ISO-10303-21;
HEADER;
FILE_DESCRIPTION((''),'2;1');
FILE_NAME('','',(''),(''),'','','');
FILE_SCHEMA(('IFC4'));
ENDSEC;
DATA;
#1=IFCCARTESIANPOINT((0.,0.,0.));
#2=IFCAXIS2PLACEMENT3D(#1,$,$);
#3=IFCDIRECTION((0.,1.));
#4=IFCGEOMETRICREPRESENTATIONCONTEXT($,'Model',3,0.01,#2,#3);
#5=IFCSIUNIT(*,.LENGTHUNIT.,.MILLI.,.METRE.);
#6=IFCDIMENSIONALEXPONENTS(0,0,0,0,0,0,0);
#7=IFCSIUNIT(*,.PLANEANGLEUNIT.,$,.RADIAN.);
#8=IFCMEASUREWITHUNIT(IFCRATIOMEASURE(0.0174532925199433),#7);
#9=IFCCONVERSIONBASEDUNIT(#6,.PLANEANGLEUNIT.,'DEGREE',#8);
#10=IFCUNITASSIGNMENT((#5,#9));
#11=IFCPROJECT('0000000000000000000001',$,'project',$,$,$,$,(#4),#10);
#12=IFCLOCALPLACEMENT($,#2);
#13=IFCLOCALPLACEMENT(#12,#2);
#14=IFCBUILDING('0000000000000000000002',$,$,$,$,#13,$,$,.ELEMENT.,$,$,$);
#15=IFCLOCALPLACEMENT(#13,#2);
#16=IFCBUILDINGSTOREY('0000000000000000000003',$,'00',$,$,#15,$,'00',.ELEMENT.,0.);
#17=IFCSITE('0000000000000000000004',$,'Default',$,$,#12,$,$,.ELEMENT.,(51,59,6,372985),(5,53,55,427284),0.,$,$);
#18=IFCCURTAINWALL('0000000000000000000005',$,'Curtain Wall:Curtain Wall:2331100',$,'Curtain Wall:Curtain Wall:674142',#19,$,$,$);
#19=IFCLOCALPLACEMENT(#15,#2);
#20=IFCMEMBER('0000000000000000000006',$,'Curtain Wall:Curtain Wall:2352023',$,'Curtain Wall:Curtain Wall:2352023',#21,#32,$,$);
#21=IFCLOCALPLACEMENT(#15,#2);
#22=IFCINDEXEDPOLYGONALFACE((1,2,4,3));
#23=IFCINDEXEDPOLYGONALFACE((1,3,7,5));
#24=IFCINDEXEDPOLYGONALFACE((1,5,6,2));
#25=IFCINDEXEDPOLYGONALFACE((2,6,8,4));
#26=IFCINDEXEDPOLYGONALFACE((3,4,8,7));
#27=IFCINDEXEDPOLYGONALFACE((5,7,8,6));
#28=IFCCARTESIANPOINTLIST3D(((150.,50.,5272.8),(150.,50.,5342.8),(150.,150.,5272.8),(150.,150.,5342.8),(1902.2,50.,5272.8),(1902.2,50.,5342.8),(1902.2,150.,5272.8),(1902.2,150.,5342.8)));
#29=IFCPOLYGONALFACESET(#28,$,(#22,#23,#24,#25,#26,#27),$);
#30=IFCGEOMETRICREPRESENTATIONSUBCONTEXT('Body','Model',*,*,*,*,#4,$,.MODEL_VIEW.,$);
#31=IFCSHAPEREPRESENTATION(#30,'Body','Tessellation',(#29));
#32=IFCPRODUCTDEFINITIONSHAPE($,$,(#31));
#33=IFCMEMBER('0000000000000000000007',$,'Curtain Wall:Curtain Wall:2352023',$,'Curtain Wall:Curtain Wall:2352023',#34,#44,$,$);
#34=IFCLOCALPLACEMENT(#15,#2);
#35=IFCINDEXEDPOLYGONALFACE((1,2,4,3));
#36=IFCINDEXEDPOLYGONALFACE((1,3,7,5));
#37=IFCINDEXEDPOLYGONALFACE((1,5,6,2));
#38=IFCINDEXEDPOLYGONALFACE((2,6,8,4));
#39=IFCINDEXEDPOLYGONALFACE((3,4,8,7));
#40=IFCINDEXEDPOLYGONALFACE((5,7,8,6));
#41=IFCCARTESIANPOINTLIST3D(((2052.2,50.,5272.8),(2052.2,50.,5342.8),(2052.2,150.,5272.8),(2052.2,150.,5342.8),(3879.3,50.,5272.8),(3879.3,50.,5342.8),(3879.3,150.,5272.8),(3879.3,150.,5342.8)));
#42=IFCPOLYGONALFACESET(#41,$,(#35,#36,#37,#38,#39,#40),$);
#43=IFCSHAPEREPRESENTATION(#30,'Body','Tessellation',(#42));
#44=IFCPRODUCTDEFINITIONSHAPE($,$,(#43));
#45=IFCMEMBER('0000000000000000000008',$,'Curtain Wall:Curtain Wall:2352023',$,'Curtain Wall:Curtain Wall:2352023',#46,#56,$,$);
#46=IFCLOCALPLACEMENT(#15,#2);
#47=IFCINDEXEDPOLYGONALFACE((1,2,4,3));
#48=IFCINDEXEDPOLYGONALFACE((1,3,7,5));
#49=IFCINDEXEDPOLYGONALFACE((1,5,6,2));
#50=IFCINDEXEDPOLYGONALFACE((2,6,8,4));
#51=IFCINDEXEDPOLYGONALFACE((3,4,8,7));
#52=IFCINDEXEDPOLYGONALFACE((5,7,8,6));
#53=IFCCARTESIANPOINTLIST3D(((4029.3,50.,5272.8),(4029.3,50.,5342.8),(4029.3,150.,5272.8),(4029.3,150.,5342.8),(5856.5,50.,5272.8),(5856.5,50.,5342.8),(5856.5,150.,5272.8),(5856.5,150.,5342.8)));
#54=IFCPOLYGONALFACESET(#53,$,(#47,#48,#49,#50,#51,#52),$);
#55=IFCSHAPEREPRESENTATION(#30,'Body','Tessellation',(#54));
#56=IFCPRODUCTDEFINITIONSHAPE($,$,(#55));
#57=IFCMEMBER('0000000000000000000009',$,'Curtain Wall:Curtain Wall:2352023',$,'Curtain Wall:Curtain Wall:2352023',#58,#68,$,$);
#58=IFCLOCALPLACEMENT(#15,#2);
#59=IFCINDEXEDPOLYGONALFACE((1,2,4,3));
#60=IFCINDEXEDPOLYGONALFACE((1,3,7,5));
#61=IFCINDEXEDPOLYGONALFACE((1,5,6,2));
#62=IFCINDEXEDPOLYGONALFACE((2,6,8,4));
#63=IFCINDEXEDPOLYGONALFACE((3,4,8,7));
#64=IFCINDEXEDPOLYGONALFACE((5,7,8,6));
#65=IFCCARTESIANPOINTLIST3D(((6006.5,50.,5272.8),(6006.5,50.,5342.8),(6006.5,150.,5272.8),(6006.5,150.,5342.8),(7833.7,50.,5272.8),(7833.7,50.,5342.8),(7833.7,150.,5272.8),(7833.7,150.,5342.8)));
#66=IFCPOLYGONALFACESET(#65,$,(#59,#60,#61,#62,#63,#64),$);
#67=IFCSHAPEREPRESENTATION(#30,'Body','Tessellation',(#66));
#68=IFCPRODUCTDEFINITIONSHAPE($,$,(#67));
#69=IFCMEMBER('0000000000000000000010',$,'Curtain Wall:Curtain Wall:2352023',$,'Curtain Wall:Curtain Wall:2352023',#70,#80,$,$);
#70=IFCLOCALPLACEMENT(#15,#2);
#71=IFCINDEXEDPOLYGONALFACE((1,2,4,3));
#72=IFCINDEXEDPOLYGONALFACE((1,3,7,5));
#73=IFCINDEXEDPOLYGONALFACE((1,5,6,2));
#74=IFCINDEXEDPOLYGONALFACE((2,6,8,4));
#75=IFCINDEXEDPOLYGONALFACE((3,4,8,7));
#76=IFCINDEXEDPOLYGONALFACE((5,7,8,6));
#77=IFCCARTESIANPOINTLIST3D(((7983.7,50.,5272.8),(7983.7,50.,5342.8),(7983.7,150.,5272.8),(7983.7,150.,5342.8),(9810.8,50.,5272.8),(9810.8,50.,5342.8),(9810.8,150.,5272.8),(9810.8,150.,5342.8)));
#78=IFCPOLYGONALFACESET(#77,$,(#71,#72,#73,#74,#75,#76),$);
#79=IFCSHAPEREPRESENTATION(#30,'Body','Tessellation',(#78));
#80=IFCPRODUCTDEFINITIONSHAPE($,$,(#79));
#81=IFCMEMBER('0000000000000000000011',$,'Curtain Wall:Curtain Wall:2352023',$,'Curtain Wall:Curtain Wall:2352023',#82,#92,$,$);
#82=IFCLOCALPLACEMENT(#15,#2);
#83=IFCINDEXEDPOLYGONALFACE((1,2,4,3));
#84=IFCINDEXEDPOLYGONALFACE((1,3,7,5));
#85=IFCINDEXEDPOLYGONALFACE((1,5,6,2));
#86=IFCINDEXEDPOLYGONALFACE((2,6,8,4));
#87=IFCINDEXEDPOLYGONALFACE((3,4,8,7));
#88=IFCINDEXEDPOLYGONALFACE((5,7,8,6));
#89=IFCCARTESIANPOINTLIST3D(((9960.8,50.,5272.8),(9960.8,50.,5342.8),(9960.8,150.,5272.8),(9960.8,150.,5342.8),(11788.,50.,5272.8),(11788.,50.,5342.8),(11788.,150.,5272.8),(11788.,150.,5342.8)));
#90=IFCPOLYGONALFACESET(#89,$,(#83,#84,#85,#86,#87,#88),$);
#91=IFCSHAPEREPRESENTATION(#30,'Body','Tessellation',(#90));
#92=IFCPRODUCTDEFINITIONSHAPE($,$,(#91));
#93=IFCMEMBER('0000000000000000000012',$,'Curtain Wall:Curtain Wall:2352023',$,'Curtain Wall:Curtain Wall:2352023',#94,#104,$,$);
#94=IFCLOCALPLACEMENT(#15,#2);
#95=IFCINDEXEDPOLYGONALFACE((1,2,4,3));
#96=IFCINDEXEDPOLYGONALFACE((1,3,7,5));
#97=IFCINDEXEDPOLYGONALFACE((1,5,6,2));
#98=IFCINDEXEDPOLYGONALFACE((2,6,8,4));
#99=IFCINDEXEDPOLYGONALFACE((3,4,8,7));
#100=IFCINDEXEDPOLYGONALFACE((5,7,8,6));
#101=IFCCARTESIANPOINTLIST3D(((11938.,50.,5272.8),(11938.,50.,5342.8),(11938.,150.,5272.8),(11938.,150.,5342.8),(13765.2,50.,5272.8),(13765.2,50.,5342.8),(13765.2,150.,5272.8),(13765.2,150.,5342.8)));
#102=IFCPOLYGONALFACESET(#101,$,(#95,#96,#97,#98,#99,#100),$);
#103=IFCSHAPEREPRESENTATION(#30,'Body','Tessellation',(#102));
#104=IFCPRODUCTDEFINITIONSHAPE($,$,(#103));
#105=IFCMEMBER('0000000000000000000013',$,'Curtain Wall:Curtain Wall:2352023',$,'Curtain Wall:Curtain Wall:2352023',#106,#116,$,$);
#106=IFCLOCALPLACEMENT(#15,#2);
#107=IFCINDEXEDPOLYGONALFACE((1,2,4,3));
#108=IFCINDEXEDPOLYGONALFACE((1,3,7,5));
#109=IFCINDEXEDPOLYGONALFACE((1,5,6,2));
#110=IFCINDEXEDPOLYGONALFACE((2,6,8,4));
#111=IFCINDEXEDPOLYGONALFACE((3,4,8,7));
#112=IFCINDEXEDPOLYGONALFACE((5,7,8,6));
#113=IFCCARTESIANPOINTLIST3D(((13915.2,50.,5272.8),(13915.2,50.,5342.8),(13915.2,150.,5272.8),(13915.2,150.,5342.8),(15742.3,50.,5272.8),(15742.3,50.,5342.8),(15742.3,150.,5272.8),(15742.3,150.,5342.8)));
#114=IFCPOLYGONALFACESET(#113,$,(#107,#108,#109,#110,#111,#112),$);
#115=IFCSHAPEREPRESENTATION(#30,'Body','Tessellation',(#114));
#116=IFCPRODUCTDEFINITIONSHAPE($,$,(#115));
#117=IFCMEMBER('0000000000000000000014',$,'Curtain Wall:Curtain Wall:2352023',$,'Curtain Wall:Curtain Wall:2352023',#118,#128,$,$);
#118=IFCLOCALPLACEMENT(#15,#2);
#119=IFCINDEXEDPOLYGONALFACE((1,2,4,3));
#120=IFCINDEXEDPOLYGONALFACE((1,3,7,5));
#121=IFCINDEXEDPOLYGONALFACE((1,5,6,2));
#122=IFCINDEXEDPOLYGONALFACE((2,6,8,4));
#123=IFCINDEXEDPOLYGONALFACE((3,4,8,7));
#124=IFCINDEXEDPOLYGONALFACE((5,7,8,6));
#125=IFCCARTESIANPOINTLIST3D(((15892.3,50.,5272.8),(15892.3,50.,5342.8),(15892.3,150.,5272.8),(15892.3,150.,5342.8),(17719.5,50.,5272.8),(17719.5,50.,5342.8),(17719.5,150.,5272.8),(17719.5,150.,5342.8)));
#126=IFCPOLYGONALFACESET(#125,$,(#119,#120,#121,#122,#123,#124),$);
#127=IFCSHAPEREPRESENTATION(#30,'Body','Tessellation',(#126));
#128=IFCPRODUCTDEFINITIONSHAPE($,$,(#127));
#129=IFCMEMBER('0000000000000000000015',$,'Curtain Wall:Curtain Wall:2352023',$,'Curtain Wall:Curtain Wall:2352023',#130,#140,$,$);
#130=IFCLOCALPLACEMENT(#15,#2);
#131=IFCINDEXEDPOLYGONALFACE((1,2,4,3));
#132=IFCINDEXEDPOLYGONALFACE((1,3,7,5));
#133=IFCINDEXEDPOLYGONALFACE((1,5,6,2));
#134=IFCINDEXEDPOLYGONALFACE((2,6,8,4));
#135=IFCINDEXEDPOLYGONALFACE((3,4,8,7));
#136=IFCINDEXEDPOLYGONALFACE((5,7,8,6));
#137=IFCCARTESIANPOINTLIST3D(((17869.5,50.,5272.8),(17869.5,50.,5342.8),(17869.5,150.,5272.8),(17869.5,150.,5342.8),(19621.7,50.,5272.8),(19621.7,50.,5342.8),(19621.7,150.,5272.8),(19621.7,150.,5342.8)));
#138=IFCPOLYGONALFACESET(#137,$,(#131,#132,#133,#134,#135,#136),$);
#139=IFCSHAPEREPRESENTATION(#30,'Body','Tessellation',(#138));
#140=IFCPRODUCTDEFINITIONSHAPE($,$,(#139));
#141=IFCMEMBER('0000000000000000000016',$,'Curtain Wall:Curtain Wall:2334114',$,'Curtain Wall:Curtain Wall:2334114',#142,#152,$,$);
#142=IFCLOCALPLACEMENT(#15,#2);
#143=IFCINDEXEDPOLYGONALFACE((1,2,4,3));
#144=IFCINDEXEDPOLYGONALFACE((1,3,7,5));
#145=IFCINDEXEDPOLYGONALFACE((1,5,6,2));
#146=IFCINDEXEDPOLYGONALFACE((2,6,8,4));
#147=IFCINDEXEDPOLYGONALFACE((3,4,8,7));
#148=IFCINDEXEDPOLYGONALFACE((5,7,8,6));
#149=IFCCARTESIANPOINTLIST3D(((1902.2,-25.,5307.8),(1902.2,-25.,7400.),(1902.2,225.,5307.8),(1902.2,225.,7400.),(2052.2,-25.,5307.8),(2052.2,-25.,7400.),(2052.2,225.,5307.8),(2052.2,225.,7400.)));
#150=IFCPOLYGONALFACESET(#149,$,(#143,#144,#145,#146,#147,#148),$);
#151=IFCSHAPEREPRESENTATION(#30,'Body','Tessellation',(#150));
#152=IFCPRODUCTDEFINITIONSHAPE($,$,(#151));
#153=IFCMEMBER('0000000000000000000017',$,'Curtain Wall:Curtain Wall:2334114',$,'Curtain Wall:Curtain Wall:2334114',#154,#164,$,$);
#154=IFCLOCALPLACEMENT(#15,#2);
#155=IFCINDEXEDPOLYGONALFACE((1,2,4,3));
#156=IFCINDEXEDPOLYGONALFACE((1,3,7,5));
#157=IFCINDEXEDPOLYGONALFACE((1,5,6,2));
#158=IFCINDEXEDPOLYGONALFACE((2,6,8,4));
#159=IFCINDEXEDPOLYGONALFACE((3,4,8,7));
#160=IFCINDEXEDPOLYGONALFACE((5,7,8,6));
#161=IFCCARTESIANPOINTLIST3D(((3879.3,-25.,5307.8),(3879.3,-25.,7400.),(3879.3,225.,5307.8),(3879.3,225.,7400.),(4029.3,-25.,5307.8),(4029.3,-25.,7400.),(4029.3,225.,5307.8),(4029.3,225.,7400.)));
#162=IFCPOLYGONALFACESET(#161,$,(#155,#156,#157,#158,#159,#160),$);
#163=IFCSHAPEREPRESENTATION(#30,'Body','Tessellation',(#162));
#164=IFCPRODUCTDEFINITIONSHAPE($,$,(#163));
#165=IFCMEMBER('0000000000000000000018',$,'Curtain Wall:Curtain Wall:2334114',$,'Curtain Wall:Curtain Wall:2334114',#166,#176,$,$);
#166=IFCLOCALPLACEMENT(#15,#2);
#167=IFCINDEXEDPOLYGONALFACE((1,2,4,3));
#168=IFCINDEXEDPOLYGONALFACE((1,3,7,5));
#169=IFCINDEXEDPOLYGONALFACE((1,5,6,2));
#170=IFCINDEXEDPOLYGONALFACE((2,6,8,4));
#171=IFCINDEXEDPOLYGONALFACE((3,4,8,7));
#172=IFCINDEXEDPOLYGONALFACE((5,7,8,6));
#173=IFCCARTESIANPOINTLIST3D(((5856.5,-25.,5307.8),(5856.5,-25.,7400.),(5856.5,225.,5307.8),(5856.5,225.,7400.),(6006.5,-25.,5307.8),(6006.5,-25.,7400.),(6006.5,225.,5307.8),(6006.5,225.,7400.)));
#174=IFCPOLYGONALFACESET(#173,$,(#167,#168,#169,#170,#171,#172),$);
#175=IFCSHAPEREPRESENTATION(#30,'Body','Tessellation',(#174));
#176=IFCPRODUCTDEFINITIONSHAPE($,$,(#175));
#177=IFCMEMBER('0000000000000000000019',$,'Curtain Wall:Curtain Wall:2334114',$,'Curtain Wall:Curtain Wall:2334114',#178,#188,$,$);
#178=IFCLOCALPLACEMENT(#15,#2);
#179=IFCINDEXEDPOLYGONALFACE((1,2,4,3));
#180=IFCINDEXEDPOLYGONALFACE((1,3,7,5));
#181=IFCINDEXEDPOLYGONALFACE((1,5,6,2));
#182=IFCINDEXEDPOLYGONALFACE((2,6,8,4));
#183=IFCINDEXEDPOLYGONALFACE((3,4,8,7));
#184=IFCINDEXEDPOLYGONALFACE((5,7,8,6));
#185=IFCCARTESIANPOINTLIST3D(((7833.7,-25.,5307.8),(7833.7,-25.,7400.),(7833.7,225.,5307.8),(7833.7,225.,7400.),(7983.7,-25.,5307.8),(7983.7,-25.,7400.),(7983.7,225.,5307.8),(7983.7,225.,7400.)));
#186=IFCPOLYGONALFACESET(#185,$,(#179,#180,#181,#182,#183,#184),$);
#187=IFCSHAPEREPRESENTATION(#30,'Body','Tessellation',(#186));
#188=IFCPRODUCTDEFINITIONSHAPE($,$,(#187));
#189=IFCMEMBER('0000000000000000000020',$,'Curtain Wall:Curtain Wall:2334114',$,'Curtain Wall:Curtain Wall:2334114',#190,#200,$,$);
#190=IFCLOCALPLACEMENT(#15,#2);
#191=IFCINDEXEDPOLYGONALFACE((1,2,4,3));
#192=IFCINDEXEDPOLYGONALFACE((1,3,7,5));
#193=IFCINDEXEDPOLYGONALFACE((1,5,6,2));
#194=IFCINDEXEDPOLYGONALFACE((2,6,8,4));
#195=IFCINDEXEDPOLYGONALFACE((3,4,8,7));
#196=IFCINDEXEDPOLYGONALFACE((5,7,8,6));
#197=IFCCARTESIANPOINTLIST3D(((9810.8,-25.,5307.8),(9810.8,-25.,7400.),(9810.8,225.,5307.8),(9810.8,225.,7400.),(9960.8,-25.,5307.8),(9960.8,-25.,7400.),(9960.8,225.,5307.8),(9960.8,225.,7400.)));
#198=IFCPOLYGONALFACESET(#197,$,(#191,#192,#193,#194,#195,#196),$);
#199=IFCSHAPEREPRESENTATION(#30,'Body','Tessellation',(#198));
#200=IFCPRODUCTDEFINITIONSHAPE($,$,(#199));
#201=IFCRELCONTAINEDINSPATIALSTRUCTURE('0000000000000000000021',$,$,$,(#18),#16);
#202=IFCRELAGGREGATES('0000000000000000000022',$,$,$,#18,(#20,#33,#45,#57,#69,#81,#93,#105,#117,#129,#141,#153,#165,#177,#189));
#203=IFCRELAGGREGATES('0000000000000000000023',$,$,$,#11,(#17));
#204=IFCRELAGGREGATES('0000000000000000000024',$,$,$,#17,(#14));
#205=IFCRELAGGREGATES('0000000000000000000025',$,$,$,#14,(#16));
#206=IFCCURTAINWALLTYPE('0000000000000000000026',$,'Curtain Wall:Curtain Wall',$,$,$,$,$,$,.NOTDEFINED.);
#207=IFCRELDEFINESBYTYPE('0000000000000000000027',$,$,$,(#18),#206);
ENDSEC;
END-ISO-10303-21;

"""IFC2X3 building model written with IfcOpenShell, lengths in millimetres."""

from ifc_helpers import new_model, entity, si_unit, converted_unit, direction, frame, frame_2d, origin, origin_2d_with_axis, place, context, subcontext, project, spatial, rectangle, extrude, type_object, element, aggregate, save


model = new_model("IFC2X3")

# Units and contexts
model_context = context("Model", 3, precision=0.01, world=origin(), true_north=direction((0.0, 1.0)))
body_context = subcontext(model_context, "Body", "Model", "MODEL_VIEW")
ifc_project = project(units=[si_unit("LENGTHUNIT", "METRE", prefix="MILLI"), converted_unit("PLANEANGLEUNIT", "DEGREE", entity("IfcRatioMeasure", 0.0174532925199433), si_unit("PLANEANGLEUNIT", "RADIAN"), dimensions=[0, 0, 0, 0, 0, 0, 0])], contexts=[model_context])

# Site, building, storey
site_placement = place(None, origin())
site = spatial("IfcSite", under=ifc_project, at=site_placement, Name="Default", CompositionType="ELEMENT", RefLatitude=(51, 59, 6, 372985), RefLongitude=(5, 53, 55, 427284), RefElevation=0.0)
building_placement = place(site_placement, origin())
building = spatial("IfcBuilding", under=site, at=building_placement, CompositionType="ELEMENT")
storey_placement = place(building_placement, origin())
storey = spatial("IfcBuildingStorey", under=building, at=storey_placement, Name="00", LongName="00", CompositionType="ELEMENT", Elevation=0.0)

# Curtain wall, members
curtain_wall_type = type_object("IfcCurtainWallType", Name="Curtain Wall:Curtain Wall", PredefinedType="NOTDEFINED")
curtain_wall_placement = place(storey_placement, origin())
curtain_wall = element("IfcCurtainWall", 1, at=curtain_wall_placement, inside=storey, type_object=curtain_wall_type, Name="Curtain Wall:Curtain Wall:2331100", ObjectType="Curtain Wall:Curtain Wall:674142")
member_1_placement = place(curtain_wall_placement, origin())
member_1 = element("IfcMember", 2, at=member_1_placement, Name="Curtain Wall:Curtain Wall:2352023", ObjectType="Curtain Wall:Curtain Wall:2352023", context=body_context, shape_type="SweptSolid", body=[
    extrude(rectangle(XDim=70.0, YDim=100.0, at=frame_2d((0.0, 0.0), x_axis=(1.0, 0.0))), frame((1902.2, 100.0, 5307.8), z_axis=(-1.0, 0.0, 0.0), x_axis=(0.0, 0.0, -1.0)), (0.0, 0.0, 1.0), 1752.2),
])
member_2_placement = place(curtain_wall_placement, origin())
member_2 = element("IfcMember", 3, at=member_2_placement, Name="Curtain Wall:Curtain Wall:2352023", ObjectType="Curtain Wall:Curtain Wall:2352023", context=body_context, shape_type="SweptSolid", body=[
    extrude(rectangle(XDim=70.0, YDim=100.0, at=frame_2d((0.0, 0.0), x_axis=(1.0, 0.0))), frame((3879.3, 100.0, 5307.8), z_axis=(-1.0, 0.0, 0.0), x_axis=(0.0, 0.0, -1.0)), (0.0, 0.0, 1.0), 1827.2),
])
member_3_placement = place(curtain_wall_placement, origin())
member_3 = element("IfcMember", 4, at=member_3_placement, Name="Curtain Wall:Curtain Wall:2352023", ObjectType="Curtain Wall:Curtain Wall:2352023", context=body_context, shape_type="SweptSolid", body=[
    extrude(rectangle(XDim=70.0, YDim=100.0, at=frame_2d((0.0, 0.0), x_axis=(1.0, 0.0))), frame((5856.5, 100.0, 5307.8), z_axis=(-1.0, 0.0, 0.0), x_axis=(0.0, 0.0, -1.0)), (0.0, 0.0, 1.0), 1827.2),
])
member_4_placement = place(curtain_wall_placement, origin())
member_4 = element("IfcMember", 5, at=member_4_placement, Name="Curtain Wall:Curtain Wall:2352023", ObjectType="Curtain Wall:Curtain Wall:2352023", context=body_context, shape_type="SweptSolid", body=[
    extrude(rectangle(XDim=70.0, YDim=100.0, at=frame_2d((0.0, 0.0), x_axis=(1.0, 0.0))), frame((7833.7, 100.0, 5307.8), z_axis=(-1.0, 0.0, 0.0), x_axis=(0.0, 0.0, -1.0)), (0.0, 0.0, 1.0), 1827.2),
])
member_5_placement = place(curtain_wall_placement, origin())
member_5 = element("IfcMember", 6, at=member_5_placement, Name="Curtain Wall:Curtain Wall:2352023", ObjectType="Curtain Wall:Curtain Wall:2352023", context=body_context, shape_type="SweptSolid", body=[
    extrude(rectangle(XDim=70.0, YDim=100.0, at=frame_2d((0.0, 0.0), x_axis=(1.0, 0.0))), frame((9810.8, 100.0, 5307.8), z_axis=(-1.0, 0.0, 0.0), x_axis=(0.0, 0.0, -1.0)), (0.0, 0.0, 1.0), 1827.2),
])
member_6_placement = place(curtain_wall_placement, origin())
member_6 = element("IfcMember", 7, at=member_6_placement, Name="Curtain Wall:Curtain Wall:2352023", ObjectType="Curtain Wall:Curtain Wall:2352023", context=body_context, shape_type="SweptSolid", body=[
    extrude(rectangle(XDim=70.0, YDim=100.0, at=frame_2d((0.0, 0.0), x_axis=(1.0, 0.0))), frame((11788.0, 100.0, 5307.8), z_axis=(-1.0, 0.0, 0.0), x_axis=(0.0, 0.0, -1.0)), (0.0, 0.0, 1.0), 1827.2),
])
member_7_placement = place(curtain_wall_placement, origin())
member_7 = element("IfcMember", 8, at=member_7_placement, Name="Curtain Wall:Curtain Wall:2352023", ObjectType="Curtain Wall:Curtain Wall:2352023", context=body_context, shape_type="SweptSolid", body=[
    extrude(rectangle(XDim=70.0, YDim=100.0, at=frame_2d((0.0, 0.0), x_axis=(1.0, 0.0))), frame((13765.2, 100.0, 5307.8), z_axis=(-1.0, 0.0, 0.0), x_axis=(0.0, 0.0, -1.0)), (0.0, 0.0, 1.0), 1827.2),
])
member_8_placement = place(curtain_wall_placement, origin())
member_8 = element("IfcMember", 9, at=member_8_placement, Name="Curtain Wall:Curtain Wall:2352023", ObjectType="Curtain Wall:Curtain Wall:2352023", context=body_context, shape_type="SweptSolid", body=[
    extrude(rectangle(XDim=70.0, YDim=100.0, at=frame_2d((0.0, 0.0), x_axis=(1.0, 0.0))), frame((15742.3, 100.0, 5307.8), z_axis=(-1.0, 0.0, 0.0), x_axis=(0.0, 0.0, -1.0)), (0.0, 0.0, 1.0), 1827.2),
])
member_9_placement = place(curtain_wall_placement, origin())
member_9 = element("IfcMember", 10, at=member_9_placement, Name="Curtain Wall:Curtain Wall:2352023", ObjectType="Curtain Wall:Curtain Wall:2352023", context=body_context, shape_type="SweptSolid", body=[
    extrude(rectangle(XDim=70.0, YDim=100.0, at=frame_2d((0.0, 0.0), x_axis=(1.0, 0.0))), frame((17719.5, 100.0, 5307.8), z_axis=(-1.0, 0.0, 0.0), x_axis=(0.0, 0.0, -1.0)), (0.0, 0.0, 1.0), 1827.2),
])
member_10_placement = place(curtain_wall_placement, origin())
member_10 = element("IfcMember", 11, at=member_10_placement, Name="Curtain Wall:Curtain Wall:2352023", ObjectType="Curtain Wall:Curtain Wall:2352023", context=body_context, shape_type="SweptSolid", body=[
    extrude(rectangle(XDim=70.0, YDim=100.0, at=frame_2d((0.0, 0.0), x_axis=(1.0, 0.0))), frame((19621.7, 100.0, 5307.8), z_axis=(-1.0, 0.0, 0.0), x_axis=(0.0, 0.0, -1.0)), (0.0, 0.0, 1.0), 1752.2),
])
member_11_placement = place(curtain_wall_placement, origin())
member_11 = element("IfcMember", 12, at=member_11_placement, Name="Curtain Wall:Curtain Wall:2334114", ObjectType="Curtain Wall:Curtain Wall:2334114", context=body_context, shape_type="SweptSolid", body=[
    extrude(rectangle(XDim=150.0, YDim=250.0, at=frame_2d((0.0, 0.0), x_axis=(1.0, 0.0))), frame((1977.2, 100.0, 5307.8), z_axis=(0.0, 0.0, 1.0), x_axis=(-1.0, 0.0, 0.0)), (0.0, 0.0, 1.0), 2092.2),
])
member_12_placement = place(curtain_wall_placement, origin())
member_12 = element("IfcMember", 13, at=member_12_placement, Name="Curtain Wall:Curtain Wall:2334114", ObjectType="Curtain Wall:Curtain Wall:2334114", context=body_context, shape_type="SweptSolid", body=[
    extrude(rectangle(XDim=150.0, YDim=250.0, at=frame_2d((0.0, 0.0), x_axis=(1.0, 0.0))), frame((3954.3, 100.0, 5307.8), z_axis=(0.0, 0.0, 1.0), x_axis=(-1.0, 0.0, 0.0)), (0.0, 0.0, 1.0), 2092.2),
])
member_13_placement = place(curtain_wall_placement, origin())
member_13 = element("IfcMember", 14, at=member_13_placement, Name="Curtain Wall:Curtain Wall:2334114", ObjectType="Curtain Wall:Curtain Wall:2334114", context=body_context, shape_type="SweptSolid", body=[
    extrude(rectangle(XDim=150.0, YDim=250.0, at=frame_2d((0.0, 0.0), x_axis=(1.0, 0.0))), frame((5931.5, 100.0, 5307.8), z_axis=(0.0, 0.0, 1.0), x_axis=(-1.0, 0.0, 0.0)), (0.0, 0.0, 1.0), 2092.2),
])
member_14_placement = place(curtain_wall_placement, origin())
member_14 = element("IfcMember", 15, at=member_14_placement, Name="Curtain Wall:Curtain Wall:2334114", ObjectType="Curtain Wall:Curtain Wall:2334114", context=body_context, shape_type="SweptSolid", body=[
    extrude(rectangle(XDim=150.0, YDim=250.0, at=frame_2d((0.0, 0.0), x_axis=(1.0, 0.0))), frame((7908.7, 100.0, 5307.8), z_axis=(0.0, 0.0, 1.0), x_axis=(-1.0, 0.0, 0.0)), (0.0, 0.0, 1.0), 2092.2),
])
member_15_placement = place(curtain_wall_placement, origin())
member_15 = element("IfcMember", 16, at=member_15_placement, Name="Curtain Wall:Curtain Wall:2334114", ObjectType="Curtain Wall:Curtain Wall:2334114", context=body_context, shape_type="SweptSolid", body=[
    extrude(rectangle(XDim=150.0, YDim=250.0, at=origin_2d_with_axis()), frame((9885.8, 100.0, 5307.8), z_axis=(0.0, 0.0, 1.0), x_axis=(-1.0, 0.0, 0.0)), (0.0, 0.0, 1.0), 2092.2),
])
aggregate(curtain_wall, [member_1, member_2, member_3, member_4, member_5, member_6, member_7, member_8, member_9, member_10, member_11, member_12, member_13, member_14, member_15])

save(model, "model.ifc")
